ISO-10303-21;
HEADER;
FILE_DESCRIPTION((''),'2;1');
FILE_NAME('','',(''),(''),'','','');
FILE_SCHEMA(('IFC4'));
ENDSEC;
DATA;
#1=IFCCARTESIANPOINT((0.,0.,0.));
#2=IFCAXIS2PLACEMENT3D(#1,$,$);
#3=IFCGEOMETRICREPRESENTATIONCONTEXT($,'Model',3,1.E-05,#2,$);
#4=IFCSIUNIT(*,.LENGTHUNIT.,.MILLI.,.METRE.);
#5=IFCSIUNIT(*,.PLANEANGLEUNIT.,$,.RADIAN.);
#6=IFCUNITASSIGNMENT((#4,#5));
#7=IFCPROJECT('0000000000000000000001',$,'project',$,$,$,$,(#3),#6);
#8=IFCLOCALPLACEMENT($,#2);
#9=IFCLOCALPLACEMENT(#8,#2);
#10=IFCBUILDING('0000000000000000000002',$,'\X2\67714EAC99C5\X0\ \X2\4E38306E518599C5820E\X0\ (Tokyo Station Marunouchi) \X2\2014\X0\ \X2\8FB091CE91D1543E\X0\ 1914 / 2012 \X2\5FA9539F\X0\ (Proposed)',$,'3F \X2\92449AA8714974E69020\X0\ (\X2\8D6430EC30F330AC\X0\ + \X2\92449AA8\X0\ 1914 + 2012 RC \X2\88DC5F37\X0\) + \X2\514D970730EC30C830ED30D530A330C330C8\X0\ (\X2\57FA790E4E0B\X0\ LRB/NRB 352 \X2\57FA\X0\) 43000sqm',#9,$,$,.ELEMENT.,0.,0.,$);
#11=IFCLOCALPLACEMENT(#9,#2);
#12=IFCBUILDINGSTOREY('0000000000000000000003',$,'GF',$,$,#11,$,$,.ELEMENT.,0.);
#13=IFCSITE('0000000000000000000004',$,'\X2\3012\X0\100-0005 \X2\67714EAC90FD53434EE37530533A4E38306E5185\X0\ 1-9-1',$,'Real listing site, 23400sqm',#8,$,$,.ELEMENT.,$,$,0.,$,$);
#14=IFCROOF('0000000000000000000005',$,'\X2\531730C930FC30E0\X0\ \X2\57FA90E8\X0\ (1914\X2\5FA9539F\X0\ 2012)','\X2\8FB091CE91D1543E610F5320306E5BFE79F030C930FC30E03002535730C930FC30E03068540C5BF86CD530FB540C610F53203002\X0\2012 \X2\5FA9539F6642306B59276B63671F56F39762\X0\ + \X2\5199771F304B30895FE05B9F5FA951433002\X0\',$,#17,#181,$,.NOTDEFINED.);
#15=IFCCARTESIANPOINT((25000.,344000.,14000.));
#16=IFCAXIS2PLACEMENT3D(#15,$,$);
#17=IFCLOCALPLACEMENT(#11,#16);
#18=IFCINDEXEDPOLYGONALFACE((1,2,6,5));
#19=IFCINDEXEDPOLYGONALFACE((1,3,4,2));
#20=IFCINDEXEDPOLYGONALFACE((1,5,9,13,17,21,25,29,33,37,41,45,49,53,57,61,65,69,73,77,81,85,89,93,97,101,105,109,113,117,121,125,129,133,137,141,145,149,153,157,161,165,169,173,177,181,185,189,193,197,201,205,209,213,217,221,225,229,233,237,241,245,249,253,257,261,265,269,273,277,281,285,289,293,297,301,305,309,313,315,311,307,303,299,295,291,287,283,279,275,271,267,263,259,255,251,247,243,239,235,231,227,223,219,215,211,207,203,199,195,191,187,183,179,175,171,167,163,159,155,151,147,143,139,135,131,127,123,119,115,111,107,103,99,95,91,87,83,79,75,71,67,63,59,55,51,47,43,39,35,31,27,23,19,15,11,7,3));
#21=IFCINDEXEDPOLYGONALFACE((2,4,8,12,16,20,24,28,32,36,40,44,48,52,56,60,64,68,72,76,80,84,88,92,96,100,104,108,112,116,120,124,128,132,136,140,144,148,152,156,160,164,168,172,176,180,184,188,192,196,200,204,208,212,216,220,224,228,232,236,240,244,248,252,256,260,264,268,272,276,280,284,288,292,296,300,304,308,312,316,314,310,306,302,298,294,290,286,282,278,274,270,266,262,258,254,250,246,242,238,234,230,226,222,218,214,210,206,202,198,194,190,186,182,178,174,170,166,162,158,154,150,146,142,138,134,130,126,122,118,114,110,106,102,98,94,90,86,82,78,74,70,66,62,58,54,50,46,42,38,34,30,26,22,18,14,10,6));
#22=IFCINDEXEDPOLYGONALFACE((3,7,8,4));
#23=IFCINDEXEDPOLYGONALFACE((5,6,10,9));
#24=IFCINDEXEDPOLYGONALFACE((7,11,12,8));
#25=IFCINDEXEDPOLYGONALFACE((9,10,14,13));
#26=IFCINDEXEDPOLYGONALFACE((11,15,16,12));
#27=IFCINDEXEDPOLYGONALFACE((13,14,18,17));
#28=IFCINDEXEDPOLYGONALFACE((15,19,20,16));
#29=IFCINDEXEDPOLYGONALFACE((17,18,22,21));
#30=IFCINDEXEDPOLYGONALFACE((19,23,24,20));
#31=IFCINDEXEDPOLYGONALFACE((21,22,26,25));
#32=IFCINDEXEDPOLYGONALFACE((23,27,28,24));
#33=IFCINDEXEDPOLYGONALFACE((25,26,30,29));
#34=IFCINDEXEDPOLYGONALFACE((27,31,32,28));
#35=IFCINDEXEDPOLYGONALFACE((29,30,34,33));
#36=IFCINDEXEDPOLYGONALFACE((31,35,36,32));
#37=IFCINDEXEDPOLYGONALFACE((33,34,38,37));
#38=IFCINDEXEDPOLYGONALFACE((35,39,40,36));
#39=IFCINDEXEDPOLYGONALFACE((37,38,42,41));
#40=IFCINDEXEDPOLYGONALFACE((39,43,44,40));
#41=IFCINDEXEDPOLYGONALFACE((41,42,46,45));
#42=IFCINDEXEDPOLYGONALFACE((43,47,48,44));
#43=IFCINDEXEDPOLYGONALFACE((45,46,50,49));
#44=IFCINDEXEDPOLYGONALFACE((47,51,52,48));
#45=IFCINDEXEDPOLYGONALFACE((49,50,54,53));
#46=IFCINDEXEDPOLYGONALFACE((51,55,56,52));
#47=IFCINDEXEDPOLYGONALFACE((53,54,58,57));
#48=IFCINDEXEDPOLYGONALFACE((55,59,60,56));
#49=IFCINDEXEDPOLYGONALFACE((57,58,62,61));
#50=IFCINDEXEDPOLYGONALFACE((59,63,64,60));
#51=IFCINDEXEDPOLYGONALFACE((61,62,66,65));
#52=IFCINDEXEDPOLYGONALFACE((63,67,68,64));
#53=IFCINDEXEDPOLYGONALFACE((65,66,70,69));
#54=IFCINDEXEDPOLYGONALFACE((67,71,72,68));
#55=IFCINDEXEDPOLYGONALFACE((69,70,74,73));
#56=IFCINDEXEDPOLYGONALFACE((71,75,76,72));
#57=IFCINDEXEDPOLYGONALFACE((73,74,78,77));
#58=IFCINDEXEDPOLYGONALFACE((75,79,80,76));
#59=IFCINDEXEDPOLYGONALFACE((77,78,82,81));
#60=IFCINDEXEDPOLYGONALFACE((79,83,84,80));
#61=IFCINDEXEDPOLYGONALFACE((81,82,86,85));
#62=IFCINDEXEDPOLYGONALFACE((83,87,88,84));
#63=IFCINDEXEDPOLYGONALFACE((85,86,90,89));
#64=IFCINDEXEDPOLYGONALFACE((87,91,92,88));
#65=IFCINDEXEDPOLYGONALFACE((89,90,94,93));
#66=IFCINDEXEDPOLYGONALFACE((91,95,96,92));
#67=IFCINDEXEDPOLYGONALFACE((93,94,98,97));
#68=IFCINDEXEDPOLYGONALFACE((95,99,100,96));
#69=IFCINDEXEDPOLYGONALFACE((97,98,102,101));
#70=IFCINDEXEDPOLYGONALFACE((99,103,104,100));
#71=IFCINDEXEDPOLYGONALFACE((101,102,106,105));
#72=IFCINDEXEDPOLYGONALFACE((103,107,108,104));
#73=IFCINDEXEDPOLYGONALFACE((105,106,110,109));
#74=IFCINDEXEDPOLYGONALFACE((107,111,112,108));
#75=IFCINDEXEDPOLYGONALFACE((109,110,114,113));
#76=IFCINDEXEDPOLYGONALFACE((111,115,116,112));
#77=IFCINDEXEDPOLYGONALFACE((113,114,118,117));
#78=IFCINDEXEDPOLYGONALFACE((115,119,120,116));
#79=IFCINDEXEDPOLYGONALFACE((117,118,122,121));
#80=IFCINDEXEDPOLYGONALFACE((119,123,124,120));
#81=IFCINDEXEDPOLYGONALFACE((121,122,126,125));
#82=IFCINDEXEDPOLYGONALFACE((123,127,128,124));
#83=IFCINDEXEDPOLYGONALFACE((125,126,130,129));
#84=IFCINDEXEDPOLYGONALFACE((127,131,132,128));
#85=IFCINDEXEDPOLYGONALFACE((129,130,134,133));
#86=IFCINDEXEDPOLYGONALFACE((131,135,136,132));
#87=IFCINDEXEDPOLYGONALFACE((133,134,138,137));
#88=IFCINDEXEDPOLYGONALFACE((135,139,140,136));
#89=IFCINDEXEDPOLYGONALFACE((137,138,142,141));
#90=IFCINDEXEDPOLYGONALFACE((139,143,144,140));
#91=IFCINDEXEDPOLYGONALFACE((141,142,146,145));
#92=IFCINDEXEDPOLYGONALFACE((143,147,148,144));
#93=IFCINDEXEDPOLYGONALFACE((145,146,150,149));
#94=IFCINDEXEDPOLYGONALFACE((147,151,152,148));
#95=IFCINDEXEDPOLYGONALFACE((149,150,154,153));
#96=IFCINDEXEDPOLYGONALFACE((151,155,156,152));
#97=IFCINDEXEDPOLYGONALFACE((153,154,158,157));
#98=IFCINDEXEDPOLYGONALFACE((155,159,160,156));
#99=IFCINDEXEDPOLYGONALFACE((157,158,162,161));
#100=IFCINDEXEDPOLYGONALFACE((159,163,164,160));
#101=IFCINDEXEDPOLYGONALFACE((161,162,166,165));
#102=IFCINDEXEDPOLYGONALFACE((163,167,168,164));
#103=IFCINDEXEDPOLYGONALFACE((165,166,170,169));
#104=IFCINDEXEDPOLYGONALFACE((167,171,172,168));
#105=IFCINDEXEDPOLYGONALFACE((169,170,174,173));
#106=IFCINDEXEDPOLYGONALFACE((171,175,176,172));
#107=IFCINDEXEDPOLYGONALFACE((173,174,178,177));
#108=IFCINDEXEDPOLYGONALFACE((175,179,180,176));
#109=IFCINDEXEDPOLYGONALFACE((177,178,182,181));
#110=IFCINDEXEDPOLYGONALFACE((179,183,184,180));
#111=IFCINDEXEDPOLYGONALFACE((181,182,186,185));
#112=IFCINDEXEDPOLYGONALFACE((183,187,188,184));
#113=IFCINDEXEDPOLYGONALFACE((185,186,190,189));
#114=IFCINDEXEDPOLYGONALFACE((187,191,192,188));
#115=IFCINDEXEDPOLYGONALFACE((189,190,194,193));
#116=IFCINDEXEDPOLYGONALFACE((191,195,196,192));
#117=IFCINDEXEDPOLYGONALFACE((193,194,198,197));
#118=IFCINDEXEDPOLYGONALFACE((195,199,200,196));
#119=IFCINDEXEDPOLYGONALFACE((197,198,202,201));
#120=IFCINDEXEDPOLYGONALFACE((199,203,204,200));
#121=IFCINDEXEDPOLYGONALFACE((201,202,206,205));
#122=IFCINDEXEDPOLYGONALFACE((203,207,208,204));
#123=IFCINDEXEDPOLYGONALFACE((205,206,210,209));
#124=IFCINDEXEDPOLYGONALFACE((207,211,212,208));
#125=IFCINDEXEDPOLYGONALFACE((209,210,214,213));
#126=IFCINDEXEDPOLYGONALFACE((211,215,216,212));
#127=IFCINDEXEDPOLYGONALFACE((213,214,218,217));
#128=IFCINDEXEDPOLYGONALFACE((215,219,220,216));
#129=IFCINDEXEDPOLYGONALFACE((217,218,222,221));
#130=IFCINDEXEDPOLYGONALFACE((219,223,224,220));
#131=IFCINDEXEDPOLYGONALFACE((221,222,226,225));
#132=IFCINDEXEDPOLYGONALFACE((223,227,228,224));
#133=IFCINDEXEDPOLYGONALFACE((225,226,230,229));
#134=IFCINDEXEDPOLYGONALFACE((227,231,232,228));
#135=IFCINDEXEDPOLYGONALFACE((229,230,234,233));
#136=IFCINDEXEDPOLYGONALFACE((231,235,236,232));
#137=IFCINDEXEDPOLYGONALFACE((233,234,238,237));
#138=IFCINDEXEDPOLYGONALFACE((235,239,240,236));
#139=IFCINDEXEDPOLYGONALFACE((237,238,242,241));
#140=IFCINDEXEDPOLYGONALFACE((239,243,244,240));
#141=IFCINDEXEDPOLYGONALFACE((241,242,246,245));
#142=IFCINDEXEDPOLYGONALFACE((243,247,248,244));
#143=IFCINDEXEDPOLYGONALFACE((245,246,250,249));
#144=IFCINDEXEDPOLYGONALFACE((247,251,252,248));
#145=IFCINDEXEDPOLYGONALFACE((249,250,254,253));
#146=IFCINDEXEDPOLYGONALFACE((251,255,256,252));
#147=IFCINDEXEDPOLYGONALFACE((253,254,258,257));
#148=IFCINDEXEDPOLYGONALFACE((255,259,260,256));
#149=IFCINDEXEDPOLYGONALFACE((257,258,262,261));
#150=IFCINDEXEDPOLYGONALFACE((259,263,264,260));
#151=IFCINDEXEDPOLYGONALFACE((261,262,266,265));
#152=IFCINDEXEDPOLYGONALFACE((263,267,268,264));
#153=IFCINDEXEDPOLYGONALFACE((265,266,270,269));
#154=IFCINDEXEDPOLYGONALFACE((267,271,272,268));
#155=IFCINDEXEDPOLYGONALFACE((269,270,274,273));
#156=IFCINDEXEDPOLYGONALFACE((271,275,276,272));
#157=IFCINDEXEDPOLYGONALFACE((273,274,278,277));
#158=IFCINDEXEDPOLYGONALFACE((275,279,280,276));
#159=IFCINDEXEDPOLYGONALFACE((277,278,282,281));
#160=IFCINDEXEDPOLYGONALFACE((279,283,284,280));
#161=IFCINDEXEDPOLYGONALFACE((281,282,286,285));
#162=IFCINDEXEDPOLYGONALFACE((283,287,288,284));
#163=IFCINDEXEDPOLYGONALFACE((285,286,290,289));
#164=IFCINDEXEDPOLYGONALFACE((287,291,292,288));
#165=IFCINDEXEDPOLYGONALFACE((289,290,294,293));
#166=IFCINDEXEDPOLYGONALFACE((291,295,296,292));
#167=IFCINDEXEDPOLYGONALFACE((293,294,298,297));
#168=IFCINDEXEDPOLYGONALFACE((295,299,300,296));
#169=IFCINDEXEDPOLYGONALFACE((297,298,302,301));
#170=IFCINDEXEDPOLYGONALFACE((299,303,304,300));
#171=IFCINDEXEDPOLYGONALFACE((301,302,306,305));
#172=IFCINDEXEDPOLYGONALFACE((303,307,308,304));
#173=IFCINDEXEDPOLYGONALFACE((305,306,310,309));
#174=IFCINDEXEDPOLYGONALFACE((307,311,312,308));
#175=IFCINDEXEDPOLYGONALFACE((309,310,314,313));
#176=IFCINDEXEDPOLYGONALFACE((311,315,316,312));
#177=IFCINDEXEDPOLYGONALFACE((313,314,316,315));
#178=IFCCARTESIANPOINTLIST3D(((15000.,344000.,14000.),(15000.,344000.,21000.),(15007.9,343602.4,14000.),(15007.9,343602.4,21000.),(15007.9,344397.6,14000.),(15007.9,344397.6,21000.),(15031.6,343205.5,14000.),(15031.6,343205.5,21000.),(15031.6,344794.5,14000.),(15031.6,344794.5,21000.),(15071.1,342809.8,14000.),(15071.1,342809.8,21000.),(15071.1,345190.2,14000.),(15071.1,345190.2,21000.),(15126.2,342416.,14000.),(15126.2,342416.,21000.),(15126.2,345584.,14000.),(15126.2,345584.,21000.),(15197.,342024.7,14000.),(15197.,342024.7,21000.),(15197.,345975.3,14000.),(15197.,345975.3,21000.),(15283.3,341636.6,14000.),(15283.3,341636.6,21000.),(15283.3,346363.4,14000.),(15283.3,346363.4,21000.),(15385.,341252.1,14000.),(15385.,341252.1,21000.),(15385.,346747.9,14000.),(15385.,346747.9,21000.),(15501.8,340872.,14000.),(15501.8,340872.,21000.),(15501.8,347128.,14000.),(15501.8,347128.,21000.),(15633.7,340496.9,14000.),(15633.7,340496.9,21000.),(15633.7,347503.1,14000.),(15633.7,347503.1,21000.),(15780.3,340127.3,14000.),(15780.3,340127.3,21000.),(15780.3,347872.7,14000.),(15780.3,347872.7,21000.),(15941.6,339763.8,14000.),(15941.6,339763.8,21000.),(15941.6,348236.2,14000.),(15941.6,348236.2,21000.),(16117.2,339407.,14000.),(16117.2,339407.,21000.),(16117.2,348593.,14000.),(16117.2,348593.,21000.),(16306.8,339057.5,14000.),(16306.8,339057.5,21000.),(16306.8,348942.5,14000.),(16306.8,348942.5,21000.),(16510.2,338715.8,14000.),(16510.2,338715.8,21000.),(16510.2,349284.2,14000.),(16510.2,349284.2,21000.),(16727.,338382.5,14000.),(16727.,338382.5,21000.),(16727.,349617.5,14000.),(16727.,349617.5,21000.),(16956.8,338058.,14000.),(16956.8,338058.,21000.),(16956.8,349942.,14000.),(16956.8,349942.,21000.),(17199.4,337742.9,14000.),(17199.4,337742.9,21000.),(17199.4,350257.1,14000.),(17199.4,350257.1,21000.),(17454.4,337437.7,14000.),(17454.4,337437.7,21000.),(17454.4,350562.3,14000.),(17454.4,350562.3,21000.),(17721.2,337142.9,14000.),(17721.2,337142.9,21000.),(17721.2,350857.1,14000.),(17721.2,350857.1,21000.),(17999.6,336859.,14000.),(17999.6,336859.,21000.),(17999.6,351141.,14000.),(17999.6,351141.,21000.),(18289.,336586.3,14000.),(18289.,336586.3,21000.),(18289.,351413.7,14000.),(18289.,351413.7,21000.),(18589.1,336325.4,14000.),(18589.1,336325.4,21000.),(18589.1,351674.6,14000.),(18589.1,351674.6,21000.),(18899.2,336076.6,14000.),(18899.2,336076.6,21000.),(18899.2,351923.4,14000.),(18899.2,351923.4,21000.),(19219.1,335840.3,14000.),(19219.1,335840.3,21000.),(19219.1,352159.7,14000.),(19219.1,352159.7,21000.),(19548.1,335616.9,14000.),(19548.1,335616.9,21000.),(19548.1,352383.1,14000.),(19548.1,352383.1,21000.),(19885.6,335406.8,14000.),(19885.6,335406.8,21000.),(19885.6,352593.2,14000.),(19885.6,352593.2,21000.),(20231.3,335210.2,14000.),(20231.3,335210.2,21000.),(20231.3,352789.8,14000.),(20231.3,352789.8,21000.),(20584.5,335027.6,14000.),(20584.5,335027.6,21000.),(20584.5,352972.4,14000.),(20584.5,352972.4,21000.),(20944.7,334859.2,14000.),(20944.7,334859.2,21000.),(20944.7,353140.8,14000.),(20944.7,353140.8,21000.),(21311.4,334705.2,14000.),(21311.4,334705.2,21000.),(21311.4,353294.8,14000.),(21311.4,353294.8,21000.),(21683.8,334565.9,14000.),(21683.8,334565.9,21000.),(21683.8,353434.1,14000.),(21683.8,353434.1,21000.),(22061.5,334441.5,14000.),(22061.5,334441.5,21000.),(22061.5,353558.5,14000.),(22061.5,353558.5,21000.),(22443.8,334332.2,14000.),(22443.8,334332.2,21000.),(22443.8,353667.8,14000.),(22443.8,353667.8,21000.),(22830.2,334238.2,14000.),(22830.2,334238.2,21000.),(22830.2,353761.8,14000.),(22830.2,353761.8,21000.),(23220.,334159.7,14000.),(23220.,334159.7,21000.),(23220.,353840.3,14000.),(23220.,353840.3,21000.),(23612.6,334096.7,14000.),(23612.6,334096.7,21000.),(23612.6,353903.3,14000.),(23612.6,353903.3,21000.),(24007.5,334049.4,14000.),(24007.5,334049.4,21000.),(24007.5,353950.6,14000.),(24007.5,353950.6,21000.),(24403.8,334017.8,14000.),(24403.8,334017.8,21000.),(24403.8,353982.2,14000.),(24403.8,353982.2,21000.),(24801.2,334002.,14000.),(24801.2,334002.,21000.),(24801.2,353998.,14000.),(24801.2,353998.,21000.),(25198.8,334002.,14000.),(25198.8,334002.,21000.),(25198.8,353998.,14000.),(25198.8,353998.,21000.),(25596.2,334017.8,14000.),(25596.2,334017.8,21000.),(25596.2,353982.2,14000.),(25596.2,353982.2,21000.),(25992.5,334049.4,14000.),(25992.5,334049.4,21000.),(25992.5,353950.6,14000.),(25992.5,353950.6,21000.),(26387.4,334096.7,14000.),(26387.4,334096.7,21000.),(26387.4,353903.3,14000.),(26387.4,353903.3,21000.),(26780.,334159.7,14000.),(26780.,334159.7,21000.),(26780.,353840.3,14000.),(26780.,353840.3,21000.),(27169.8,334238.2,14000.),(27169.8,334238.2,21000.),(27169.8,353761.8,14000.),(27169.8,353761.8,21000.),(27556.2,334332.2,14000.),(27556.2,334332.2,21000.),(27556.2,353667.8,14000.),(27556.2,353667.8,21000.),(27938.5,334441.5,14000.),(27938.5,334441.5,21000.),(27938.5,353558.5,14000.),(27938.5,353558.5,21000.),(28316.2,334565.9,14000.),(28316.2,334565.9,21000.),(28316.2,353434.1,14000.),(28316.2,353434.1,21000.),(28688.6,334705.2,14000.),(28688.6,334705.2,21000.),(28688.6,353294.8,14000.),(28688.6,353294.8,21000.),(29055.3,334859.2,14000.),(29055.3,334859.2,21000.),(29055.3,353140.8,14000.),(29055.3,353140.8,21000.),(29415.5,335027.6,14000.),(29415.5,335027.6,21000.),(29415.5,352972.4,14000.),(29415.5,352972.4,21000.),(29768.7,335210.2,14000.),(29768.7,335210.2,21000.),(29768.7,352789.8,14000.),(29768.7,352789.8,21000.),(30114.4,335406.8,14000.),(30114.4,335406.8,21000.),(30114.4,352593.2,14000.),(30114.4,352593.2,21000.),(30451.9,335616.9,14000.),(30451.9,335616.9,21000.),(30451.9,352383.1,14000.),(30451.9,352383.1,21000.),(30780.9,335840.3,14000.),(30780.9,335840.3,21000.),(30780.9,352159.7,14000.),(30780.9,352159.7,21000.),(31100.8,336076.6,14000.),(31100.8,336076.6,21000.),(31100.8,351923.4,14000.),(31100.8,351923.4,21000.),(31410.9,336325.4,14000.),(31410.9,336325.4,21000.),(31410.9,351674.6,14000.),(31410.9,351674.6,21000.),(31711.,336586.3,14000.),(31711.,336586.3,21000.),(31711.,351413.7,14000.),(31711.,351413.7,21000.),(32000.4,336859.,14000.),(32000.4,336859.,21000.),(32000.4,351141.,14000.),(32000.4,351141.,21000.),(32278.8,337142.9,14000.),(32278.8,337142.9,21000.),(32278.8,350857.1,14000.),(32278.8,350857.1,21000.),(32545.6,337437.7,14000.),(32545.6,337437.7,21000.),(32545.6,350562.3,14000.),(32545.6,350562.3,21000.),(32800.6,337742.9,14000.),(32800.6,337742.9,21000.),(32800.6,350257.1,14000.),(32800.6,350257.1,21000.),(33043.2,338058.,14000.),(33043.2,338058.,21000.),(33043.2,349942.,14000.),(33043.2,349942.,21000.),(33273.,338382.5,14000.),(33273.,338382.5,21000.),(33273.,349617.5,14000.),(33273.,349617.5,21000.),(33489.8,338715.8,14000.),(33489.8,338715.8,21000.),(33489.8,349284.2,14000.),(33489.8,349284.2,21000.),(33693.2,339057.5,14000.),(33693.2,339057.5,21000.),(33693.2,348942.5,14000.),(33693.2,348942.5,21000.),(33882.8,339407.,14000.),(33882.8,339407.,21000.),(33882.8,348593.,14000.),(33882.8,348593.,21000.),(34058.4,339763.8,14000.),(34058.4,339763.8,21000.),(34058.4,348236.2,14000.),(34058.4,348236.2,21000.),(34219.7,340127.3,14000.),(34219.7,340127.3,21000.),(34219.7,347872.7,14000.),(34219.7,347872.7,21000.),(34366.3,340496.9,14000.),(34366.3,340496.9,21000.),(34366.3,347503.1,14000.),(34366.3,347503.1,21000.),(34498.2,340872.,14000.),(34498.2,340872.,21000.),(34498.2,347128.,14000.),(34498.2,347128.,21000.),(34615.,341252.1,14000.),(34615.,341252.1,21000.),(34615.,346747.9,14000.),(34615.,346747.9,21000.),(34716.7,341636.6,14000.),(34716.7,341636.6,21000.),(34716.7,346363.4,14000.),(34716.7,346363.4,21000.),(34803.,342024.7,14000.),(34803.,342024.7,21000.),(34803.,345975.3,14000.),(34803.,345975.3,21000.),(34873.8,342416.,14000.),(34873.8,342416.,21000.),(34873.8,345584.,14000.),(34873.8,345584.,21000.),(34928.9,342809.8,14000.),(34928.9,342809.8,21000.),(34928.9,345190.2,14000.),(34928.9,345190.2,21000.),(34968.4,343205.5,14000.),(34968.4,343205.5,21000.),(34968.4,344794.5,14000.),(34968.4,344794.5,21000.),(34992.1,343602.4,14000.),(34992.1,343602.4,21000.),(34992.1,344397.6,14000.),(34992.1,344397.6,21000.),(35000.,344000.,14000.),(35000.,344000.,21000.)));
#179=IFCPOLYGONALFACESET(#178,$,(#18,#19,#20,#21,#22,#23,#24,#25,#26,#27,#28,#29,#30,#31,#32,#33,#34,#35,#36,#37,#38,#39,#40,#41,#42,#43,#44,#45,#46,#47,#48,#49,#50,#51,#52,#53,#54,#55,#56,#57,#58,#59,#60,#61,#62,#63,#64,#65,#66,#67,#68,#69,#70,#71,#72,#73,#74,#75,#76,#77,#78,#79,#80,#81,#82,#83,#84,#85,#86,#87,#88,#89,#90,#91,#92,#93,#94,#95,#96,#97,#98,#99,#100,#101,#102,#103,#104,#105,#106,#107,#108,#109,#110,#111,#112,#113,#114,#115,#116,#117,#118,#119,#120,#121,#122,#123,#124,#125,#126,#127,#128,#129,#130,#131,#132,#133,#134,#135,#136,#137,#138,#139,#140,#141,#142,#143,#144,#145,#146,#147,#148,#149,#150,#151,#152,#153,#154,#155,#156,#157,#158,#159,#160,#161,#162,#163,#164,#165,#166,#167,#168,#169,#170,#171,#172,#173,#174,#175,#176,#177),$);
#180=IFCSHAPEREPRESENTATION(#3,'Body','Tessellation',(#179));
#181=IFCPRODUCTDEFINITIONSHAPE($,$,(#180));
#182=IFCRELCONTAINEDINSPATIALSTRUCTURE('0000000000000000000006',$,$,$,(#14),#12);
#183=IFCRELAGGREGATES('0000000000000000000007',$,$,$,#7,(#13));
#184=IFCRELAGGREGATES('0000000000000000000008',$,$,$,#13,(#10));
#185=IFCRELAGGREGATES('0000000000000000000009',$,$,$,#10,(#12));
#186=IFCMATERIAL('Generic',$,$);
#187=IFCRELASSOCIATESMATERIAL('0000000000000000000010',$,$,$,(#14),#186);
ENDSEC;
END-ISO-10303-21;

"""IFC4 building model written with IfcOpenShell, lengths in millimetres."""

from ifc_helpers import new_model, si_unit, frame, origin, origin_2d, place, context, project, spatial, circle, extrude, material, element, save


model = new_model("IFC4")

# Units and contexts
model_context = context("Model", 3, precision=1e-05, world=origin())
ifc_project = project(units=[si_unit("LENGTHUNIT", "METRE", prefix="MILLI"), si_unit("PLANEANGLEUNIT", "RADIAN")], contexts=[model_context])

# Site, building, storey
site_placement = place(None, origin())
site = spatial("IfcSite", under=ifc_project, at=site_placement, Name="〒100-0005 東京都千代田区丸の内 1-9-1", ObjectType="Real listing site, 23400sqm", CompositionType="ELEMENT", RefElevation=0.0)
building_placement = place(site_placement, origin())
building = spatial("IfcBuilding", under=site, at=building_placement, Name="東京駅 丸の内駅舎 (Tokyo Station Marunouchi) — 辰野金吾 1914 / 2012 復原 (Proposed)", ObjectType="3F 鉄骨煉瓦造 (赤レンガ + 鉄骨 1914 + 2012 RC 補強) + 免震レトロフィット (基礎下 LRB/NRB 352 基) 43000sqm", CompositionType="ELEMENT", ElevationOfRefHeight=0.0, ElevationOfTerrain=0.0)
storey_placement = place(building_placement, origin())
storey = spatial("IfcBuildingStorey", under=building, at=storey_placement, Name="GF", CompositionType="ELEMENT", Elevation=0.0)

# Shared definitions
ifc_material_1 = material(Name="Generic")

# Roof
roof_1_placement = place(storey_placement, frame((25000.0, 344000.0, 14000.0)))
element("IfcRoof", 1, at=roof_1_placement, inside=storey, material=ifc_material_1, Name="北ドーム 基部 (1914復原 2012)", Description="辰野金吾意匠の対称ドーム。南ドームと同寸法・同意匠。2012 復原時に大正期図面 + 写真から忠実復元。", PredefinedType="NOTDEFINED", context=model_context, shape_type="SweptSolid", body=[
    extrude(circle(Radius=10000.0, at=origin_2d()), frame((25000.0, 344000.0, 14000.0)), (0.0, 0.0, 1.0), 7000.0),
])

save(model, "model.ifc")
